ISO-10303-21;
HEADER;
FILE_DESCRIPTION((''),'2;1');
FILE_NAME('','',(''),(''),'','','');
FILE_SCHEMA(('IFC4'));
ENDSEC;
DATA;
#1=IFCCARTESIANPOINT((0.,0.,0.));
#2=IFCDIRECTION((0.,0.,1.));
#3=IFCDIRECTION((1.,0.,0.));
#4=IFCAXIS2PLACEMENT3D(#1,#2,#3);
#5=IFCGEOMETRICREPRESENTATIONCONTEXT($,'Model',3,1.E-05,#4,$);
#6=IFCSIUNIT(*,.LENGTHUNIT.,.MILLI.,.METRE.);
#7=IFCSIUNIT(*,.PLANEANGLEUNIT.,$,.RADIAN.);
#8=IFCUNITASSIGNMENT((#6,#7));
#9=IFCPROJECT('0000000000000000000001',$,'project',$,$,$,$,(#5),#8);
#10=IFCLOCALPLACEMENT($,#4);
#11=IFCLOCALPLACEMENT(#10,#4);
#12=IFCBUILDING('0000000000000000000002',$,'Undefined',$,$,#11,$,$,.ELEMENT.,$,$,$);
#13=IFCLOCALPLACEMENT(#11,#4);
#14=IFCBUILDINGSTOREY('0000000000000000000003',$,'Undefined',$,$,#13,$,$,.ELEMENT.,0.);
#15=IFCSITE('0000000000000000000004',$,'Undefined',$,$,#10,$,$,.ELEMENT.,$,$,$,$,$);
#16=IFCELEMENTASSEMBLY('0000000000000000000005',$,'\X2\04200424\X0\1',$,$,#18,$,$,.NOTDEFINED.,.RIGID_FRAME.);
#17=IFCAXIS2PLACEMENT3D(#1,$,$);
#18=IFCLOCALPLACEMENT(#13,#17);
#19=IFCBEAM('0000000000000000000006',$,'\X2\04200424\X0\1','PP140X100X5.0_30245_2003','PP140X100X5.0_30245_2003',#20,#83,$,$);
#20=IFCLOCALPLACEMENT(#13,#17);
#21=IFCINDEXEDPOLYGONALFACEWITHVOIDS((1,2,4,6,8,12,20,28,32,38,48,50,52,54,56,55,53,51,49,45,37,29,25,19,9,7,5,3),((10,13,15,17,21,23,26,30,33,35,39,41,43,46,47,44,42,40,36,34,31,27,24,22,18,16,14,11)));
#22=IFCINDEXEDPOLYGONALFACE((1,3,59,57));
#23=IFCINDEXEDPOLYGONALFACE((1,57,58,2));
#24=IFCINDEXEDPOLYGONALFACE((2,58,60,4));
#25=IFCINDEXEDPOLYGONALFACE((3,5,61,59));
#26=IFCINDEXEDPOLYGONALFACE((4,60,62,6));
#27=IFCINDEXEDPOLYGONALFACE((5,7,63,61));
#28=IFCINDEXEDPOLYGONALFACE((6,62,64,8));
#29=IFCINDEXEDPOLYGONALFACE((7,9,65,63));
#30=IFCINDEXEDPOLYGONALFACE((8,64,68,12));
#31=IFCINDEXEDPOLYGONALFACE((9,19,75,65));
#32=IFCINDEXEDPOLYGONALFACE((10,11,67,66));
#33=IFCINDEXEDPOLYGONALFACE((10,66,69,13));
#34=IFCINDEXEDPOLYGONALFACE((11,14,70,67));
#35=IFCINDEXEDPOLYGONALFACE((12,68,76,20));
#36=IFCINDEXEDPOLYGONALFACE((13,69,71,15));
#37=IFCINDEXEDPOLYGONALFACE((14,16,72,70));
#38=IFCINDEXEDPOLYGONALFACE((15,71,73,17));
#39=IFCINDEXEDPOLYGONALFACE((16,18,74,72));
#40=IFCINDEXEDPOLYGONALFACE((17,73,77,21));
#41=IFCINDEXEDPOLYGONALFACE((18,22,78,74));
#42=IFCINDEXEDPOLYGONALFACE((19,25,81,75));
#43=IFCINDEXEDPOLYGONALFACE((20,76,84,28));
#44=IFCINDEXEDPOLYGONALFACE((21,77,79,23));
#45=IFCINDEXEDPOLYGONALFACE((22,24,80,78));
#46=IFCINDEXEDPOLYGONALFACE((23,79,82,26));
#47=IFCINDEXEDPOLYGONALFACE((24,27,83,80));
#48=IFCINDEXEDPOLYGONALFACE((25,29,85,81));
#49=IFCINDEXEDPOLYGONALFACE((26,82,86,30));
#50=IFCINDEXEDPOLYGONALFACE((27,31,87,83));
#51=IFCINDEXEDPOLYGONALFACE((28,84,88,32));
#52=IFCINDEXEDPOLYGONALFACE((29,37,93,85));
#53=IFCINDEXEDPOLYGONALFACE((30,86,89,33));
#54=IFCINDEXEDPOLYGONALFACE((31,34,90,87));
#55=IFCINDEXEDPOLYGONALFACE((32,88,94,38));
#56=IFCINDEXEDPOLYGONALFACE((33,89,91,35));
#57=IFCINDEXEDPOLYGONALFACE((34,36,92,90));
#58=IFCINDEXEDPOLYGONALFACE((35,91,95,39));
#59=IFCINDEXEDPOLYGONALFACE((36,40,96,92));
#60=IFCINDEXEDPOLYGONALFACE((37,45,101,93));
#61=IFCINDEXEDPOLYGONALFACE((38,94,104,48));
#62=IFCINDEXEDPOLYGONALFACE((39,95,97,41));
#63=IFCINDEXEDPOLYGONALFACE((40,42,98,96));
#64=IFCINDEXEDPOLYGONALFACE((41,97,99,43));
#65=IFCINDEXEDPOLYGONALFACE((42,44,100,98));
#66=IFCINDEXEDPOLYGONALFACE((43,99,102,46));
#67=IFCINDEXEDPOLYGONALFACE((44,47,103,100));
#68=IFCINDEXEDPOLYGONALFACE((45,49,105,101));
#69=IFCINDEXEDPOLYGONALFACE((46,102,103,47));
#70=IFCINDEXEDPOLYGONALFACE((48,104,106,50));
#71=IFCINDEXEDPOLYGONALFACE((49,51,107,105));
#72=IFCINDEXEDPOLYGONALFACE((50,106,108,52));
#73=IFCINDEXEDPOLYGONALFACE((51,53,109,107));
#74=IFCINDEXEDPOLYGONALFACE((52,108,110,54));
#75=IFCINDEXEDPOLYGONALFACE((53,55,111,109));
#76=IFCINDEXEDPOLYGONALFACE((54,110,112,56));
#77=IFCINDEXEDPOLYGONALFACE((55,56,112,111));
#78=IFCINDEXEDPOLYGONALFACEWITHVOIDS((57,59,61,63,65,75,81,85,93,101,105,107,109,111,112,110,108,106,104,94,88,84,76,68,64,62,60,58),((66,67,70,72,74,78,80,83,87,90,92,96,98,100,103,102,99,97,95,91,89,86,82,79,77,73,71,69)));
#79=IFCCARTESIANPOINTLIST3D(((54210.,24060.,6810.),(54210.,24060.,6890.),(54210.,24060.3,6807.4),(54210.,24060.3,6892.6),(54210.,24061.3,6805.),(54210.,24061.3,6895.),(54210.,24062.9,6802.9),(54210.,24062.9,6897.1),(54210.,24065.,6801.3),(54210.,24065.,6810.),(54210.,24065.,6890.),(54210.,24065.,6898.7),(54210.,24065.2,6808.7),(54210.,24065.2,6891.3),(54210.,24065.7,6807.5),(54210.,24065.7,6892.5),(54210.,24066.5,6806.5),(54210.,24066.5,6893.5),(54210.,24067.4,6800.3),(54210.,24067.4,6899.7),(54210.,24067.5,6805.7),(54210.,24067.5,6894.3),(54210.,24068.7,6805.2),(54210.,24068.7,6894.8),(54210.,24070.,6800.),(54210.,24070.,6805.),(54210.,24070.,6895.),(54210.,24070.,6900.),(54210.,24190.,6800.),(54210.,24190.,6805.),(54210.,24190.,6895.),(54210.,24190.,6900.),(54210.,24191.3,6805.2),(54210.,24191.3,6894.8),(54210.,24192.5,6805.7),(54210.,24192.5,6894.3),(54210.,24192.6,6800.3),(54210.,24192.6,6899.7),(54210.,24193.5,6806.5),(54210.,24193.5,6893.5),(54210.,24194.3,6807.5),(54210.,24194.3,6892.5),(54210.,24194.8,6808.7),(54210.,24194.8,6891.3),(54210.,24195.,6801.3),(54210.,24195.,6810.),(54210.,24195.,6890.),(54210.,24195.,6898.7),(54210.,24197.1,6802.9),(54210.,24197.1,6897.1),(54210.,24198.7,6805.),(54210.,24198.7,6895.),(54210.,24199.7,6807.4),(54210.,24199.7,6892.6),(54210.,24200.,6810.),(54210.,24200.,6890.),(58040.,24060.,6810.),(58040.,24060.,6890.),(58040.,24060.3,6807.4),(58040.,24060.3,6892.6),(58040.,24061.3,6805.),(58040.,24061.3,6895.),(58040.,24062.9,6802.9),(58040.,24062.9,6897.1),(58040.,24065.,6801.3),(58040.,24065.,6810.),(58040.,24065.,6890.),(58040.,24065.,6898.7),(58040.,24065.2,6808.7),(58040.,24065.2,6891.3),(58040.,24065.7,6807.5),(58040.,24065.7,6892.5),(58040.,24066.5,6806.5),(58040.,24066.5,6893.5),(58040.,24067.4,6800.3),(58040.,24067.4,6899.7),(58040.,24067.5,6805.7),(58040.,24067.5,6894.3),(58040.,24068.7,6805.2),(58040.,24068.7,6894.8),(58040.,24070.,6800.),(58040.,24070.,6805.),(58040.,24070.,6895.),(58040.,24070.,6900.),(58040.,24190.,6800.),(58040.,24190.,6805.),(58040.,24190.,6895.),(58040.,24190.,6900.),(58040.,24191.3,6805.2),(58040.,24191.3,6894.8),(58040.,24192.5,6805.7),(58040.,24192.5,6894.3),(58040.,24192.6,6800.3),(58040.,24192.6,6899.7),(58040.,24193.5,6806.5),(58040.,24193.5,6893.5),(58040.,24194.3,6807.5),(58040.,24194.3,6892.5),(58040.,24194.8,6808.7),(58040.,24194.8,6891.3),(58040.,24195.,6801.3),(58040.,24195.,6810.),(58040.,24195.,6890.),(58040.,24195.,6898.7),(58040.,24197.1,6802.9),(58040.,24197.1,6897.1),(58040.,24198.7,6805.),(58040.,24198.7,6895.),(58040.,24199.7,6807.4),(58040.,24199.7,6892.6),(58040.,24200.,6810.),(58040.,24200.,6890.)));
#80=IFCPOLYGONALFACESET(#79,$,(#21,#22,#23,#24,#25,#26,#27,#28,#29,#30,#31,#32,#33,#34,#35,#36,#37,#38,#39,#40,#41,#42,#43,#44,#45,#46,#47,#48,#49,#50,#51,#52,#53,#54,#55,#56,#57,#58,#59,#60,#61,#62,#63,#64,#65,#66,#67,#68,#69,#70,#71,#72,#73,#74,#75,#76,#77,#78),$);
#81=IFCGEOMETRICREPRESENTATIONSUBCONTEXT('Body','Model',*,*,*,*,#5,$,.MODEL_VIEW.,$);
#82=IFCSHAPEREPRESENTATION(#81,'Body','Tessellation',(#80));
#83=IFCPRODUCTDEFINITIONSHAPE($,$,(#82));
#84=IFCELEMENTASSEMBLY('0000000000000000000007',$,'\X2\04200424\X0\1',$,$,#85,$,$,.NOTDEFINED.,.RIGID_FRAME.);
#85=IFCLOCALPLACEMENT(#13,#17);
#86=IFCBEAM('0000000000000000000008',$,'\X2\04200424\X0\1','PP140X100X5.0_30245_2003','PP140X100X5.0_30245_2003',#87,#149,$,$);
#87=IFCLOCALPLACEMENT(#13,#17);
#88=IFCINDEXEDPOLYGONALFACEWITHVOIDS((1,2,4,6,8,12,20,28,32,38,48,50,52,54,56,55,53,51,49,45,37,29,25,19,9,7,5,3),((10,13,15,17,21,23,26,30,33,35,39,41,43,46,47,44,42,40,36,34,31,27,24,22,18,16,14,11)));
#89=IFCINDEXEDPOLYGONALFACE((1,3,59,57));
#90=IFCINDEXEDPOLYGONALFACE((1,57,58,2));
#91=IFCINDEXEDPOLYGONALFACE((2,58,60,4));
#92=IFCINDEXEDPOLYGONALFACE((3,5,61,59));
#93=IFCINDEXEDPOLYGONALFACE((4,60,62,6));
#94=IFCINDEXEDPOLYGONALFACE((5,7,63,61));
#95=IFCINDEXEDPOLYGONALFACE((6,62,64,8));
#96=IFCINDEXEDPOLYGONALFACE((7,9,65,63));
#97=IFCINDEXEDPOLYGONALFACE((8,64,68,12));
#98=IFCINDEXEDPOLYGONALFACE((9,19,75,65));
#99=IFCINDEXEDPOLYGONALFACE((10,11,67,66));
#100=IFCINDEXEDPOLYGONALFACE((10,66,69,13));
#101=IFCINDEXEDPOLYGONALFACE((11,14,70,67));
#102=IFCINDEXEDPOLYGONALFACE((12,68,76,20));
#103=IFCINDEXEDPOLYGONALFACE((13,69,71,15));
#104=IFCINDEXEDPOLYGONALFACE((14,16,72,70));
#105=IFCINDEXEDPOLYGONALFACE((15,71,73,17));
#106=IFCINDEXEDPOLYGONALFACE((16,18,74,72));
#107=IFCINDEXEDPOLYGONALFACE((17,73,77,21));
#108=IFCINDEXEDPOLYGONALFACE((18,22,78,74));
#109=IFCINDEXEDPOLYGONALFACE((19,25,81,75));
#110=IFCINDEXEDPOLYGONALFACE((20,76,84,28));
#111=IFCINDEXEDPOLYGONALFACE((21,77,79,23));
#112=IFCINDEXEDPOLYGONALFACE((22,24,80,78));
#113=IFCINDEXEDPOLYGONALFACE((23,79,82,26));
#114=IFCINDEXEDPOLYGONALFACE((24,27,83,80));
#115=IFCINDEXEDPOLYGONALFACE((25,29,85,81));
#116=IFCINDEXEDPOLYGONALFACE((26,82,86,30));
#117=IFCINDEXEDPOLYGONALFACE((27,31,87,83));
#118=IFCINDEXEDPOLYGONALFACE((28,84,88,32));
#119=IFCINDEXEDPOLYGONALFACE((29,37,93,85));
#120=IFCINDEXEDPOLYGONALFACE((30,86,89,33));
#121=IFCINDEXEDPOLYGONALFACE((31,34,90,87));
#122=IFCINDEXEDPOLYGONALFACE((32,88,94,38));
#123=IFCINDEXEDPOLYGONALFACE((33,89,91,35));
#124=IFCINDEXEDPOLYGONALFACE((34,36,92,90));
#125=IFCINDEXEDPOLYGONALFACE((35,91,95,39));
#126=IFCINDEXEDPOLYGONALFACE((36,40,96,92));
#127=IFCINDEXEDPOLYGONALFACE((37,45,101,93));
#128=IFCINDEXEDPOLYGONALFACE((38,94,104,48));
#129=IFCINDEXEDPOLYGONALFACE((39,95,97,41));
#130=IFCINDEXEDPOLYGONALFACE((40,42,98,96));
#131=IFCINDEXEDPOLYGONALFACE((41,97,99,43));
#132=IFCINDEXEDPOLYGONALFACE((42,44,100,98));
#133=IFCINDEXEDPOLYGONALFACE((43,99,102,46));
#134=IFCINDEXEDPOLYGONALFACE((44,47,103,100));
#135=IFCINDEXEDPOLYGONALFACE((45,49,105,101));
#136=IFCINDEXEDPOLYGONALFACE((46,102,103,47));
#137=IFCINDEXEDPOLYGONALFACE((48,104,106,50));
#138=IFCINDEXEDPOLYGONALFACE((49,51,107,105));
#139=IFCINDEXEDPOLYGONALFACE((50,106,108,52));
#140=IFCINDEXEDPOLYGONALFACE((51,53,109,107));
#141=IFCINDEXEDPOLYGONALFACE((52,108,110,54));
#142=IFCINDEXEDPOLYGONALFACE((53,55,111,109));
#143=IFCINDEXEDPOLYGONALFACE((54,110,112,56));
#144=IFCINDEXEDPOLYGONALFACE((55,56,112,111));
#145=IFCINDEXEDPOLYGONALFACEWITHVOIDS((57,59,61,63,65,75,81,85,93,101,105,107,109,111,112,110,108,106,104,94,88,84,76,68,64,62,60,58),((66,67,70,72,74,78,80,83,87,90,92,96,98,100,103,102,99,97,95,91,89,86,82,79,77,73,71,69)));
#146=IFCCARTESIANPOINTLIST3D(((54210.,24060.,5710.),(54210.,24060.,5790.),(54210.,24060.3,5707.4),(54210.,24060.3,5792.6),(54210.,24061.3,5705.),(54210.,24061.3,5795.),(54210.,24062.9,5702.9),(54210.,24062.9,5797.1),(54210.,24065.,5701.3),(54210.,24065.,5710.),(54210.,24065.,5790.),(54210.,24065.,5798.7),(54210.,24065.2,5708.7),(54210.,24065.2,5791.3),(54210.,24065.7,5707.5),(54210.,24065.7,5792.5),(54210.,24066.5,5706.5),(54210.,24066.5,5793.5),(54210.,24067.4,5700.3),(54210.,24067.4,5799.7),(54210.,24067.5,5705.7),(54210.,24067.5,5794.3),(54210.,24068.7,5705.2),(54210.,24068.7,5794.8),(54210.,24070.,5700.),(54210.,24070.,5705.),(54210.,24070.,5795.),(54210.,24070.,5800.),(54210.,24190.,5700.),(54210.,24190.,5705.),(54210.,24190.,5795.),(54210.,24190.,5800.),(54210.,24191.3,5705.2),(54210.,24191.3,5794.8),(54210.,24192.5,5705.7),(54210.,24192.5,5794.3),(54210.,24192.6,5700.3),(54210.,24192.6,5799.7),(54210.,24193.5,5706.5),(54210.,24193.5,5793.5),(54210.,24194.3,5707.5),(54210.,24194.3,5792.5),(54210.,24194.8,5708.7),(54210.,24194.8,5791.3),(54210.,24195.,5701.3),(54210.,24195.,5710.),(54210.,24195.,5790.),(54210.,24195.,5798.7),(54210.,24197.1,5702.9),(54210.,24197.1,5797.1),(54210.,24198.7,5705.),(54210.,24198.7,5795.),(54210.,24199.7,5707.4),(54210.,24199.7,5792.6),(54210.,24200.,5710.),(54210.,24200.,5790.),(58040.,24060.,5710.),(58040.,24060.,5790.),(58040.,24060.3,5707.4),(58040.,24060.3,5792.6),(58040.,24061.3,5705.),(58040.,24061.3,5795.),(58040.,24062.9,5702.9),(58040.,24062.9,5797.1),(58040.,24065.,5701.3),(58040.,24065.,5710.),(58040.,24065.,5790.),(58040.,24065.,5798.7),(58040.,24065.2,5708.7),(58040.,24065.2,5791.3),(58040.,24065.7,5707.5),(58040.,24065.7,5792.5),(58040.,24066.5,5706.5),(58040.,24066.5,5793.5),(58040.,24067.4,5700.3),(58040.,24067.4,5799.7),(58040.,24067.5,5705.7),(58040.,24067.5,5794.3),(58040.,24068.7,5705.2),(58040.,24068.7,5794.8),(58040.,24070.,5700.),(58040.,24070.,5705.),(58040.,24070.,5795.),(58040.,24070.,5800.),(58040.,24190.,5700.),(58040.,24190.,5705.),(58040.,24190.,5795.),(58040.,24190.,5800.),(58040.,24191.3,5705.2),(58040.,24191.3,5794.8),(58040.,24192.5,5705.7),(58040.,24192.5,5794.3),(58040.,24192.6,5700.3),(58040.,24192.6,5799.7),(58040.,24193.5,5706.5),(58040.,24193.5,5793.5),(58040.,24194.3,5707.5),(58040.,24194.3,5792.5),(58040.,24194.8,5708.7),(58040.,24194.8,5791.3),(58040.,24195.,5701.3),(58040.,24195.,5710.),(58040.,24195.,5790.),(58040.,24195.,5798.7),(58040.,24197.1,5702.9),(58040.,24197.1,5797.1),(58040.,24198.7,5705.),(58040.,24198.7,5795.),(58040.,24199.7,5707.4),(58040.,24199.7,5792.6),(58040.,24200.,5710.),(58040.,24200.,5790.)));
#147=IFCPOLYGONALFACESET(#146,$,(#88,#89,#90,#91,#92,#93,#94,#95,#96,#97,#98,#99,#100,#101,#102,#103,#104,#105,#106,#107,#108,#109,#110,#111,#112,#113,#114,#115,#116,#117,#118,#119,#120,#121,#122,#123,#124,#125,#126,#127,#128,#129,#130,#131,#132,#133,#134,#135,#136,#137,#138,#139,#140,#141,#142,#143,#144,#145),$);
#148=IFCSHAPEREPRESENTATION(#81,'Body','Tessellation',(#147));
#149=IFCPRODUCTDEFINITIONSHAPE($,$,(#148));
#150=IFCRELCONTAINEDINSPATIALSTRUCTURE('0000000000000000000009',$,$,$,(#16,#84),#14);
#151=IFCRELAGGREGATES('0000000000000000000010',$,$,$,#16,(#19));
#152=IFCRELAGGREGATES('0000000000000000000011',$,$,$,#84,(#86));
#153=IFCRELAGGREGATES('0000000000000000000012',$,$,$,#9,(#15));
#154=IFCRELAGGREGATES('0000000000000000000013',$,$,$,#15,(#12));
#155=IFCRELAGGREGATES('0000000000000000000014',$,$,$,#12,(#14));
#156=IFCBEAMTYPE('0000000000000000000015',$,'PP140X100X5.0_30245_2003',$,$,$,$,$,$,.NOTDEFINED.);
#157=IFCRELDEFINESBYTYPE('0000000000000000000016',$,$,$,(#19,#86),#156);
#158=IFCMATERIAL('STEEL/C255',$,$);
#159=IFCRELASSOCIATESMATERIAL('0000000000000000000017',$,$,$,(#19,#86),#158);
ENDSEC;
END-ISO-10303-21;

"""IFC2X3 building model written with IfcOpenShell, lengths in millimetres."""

from ifc_helpers import new_model, si_unit, frame, origin_with_axes, origin_2d_with_axis, place, context, subcontext, project, spatial, hollow_rectangle, extrude, material, type_object, element, aggregate, save


model = new_model("IFC2X3")

# Units and contexts
model_context = context("Model", 3, precision=1e-05, world=origin_with_axes())
body_context = subcontext(model_context, "Body", "Model", "MODEL_VIEW")
ifc_project = project(units=[si_unit("LENGTHUNIT", "METRE", prefix="MILLI"), si_unit("PLANEANGLEUNIT", "RADIAN")], contexts=[model_context])

# Site, building, storey
site_placement = place(None, origin_with_axes())
site = spatial("IfcSite", under=ifc_project, at=site_placement, Name="Undefined", CompositionType="ELEMENT")
building_placement = place(site_placement, origin_with_axes())
building = spatial("IfcBuilding", under=site, at=building_placement, Name="Undefined", CompositionType="ELEMENT")
storey_placement = place(building_placement, origin_with_axes())
storey = spatial("IfcBuildingStorey", under=building, at=storey_placement, Name="Undefined", CompositionType="ELEMENT", Elevation=0.0)

# Shared definitions
ifc_material_1 = material(Name="STEEL/C255")

# Element assemblies, beams
beam_type_1 = type_object("IfcBeamType", Name="PP140X100X5.0_30245_2003", PredefinedType="NOTDEFINED")
assembly_1_placement = place(storey_placement, origin_with_axes())
assembly_1 = element("IfcElementAssembly", 1, at=assembly_1_placement, inside=storey, Name="РФ1", AssemblyPlace="NOTDEFINED", PredefinedType="RIGID_FRAME")
beam_1_placement = place(assembly_1_placement, frame((54210.0, 24130.0, 6850.0), z_axis=(0.0, -1.0, 0.0), x_axis=(1.0, 0.0, 0.0)))
beam_1 = element("IfcBeam", 2, at=beam_1_placement, type_object=beam_type_1, material=ifc_material_1, Name="РФ1", Description="PP140X100X5.0_30245_2003", ObjectType="PP140X100X5.0_30245_2003", context=body_context, shape_type="SweptSolid", body=[
    extrude(hollow_rectangle(XDim=100.0, YDim=140.0, WallThickness=5.0, InnerFilletRadius=5.0, OuterFilletRadius=10.0, at=origin_2d_with_axis()), frame((3830.0, 0.0, 0.0), z_axis=(-1.0, 0.0, 0.0), x_axis=(0.0, -1.0, 0.0)), (0.0, 0.0, 1.0), 3830.0),
])
aggregate(assembly_1, [beam_1])
assembly_2_placement = place(storey_placement, origin_with_axes())
assembly_2 = element("IfcElementAssembly", 3, at=assembly_2_placement, inside=storey, Name="РФ1", AssemblyPlace="NOTDEFINED", PredefinedType="RIGID_FRAME")
beam_2_placement = place(assembly_2_placement, frame((54210.0, 24130.0, 5750.0), z_axis=(0.0, 1.0, 0.0), x_axis=(1.0, 0.0, 0.0)))
beam_2 = element("IfcBeam", 4, at=beam_2_placement, type_object=beam_type_1, material=ifc_material_1, Name="РФ1", Description="PP140X100X5.0_30245_2003", ObjectType="PP140X100X5.0_30245_2003", context=body_context, shape_type="SweptSolid", body=[
    extrude(hollow_rectangle(XDim=100.0, YDim=140.0, WallThickness=5.0, InnerFilletRadius=5.0, OuterFilletRadius=10.0, at=origin_2d_with_axis()), frame((3830.0, 0.0, 0.0), z_axis=(-1.0, 0.0, 0.0), x_axis=(0.0, -1.0, 0.0)), (0.0, 0.0, 1.0), 3830.0),
])
aggregate(assembly_2, [beam_2])

save(model, "model.ifc")
